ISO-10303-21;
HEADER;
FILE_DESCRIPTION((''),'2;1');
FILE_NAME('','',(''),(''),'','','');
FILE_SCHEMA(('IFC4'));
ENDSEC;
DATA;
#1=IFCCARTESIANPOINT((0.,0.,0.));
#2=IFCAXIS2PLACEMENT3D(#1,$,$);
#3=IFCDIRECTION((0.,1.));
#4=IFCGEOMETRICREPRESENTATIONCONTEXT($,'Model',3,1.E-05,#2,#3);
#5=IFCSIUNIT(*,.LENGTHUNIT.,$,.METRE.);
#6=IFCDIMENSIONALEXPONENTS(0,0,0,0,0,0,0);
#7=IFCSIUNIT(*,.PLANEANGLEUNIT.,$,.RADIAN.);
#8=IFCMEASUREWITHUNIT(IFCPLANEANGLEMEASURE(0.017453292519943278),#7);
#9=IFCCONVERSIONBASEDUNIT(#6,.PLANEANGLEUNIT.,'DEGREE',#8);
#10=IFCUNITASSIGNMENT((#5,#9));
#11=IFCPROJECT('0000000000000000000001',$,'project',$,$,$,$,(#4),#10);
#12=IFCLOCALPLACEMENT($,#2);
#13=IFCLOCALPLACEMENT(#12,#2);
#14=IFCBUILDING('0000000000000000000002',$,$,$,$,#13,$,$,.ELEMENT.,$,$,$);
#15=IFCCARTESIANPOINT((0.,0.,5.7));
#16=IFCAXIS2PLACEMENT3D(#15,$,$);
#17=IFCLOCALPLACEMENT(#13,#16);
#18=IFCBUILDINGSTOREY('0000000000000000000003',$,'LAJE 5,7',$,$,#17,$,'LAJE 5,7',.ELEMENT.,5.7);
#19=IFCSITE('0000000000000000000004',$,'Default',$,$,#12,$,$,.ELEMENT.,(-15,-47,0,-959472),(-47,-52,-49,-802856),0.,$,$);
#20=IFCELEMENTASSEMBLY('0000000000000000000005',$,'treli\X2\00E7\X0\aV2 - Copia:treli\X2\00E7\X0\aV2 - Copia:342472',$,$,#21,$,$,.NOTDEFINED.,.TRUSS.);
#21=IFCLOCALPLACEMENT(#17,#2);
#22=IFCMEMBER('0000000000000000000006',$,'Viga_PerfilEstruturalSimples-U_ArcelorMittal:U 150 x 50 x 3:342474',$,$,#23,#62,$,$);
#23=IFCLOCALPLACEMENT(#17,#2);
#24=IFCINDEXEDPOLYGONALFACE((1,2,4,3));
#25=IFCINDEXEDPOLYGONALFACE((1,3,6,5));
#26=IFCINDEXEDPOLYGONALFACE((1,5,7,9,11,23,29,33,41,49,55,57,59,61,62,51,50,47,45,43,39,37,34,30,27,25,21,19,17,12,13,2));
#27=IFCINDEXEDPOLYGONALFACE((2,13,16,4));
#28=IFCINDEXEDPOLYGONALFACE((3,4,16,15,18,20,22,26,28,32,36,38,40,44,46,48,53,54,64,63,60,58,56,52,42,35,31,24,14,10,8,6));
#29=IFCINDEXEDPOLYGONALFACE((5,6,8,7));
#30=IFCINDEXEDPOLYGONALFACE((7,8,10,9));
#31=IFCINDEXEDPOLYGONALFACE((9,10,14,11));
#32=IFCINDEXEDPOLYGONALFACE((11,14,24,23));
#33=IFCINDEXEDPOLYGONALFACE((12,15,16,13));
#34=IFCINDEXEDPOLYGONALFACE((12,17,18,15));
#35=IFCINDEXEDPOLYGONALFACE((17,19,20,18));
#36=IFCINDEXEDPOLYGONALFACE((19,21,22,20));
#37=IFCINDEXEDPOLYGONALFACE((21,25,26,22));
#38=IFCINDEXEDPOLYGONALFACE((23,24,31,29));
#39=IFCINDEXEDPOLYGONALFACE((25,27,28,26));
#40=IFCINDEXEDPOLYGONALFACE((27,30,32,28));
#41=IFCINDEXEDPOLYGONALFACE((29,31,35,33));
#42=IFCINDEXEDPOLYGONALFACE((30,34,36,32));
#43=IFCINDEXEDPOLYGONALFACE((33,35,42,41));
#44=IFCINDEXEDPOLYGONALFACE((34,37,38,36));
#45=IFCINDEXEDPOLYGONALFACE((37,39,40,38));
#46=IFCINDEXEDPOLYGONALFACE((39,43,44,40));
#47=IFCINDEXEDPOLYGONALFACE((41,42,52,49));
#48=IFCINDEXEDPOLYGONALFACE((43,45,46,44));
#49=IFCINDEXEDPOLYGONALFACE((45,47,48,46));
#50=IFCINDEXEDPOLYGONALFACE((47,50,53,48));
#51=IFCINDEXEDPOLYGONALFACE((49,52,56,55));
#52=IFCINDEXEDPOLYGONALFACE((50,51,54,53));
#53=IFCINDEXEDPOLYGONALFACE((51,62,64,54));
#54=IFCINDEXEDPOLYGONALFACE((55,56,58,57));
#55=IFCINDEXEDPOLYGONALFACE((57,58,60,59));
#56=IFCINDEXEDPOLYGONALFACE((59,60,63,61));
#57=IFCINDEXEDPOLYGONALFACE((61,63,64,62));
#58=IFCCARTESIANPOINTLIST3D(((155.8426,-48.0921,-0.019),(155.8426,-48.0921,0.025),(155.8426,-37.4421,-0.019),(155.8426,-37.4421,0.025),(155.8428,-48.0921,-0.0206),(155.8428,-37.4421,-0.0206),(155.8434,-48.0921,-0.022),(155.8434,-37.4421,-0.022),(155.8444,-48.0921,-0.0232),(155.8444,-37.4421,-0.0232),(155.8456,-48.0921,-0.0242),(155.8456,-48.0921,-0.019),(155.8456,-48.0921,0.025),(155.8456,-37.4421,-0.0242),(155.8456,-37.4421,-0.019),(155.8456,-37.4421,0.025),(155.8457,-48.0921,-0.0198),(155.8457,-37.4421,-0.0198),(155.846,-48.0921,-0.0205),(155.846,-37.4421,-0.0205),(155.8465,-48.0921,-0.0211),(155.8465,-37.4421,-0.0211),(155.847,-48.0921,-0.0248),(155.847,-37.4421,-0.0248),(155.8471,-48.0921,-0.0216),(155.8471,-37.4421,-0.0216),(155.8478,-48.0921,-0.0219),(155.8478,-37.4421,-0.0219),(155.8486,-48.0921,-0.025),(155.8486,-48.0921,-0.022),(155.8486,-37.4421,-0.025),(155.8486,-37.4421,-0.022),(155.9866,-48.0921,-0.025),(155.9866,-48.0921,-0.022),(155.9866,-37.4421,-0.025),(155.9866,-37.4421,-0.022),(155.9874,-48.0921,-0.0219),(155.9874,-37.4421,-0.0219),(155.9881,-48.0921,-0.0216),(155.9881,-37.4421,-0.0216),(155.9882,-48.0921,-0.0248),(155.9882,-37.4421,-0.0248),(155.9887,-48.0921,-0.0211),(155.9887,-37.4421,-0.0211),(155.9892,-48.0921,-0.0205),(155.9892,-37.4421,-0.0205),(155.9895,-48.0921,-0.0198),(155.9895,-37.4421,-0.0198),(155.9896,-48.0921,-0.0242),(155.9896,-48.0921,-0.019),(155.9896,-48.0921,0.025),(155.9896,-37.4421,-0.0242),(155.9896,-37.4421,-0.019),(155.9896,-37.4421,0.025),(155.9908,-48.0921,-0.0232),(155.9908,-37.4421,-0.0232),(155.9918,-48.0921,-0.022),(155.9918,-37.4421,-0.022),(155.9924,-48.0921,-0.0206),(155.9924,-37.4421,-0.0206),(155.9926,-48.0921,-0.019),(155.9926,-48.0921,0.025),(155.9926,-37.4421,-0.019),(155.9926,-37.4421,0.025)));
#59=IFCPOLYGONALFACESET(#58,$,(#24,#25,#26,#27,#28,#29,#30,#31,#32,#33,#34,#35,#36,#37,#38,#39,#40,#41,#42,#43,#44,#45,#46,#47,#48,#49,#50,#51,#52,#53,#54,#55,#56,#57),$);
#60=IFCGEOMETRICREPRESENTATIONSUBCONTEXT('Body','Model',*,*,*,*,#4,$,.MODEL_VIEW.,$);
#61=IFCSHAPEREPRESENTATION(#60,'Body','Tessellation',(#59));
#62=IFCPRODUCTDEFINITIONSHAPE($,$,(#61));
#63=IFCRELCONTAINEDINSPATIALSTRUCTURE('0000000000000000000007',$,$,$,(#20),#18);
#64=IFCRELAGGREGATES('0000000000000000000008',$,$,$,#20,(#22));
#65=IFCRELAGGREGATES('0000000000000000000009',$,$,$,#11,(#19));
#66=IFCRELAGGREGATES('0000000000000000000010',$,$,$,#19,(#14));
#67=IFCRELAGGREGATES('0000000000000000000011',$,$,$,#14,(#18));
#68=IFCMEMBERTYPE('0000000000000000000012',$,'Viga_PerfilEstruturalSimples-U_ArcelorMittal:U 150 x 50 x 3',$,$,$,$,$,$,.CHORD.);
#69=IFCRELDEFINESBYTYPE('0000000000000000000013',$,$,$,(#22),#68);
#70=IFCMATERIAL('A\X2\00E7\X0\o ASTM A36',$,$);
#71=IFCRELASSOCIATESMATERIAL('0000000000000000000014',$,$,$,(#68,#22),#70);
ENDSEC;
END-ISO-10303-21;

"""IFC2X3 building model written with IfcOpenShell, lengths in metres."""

from ifc_helpers import new_model, entity, si_unit, converted_unit, direction, frame, frame_2d, origin, place, context, subcontext, project, spatial, polyline, circle_curve, parameter, trimmed, segment, composite_curve, outline, extrude, source, transform, mapped, material, type_object, type_shapes, element, aggregate, save


model = new_model("IFC2X3")

# Units and contexts
model_context = context("Model", 3, precision=1e-05, world=origin(), true_north=direction((0.0, 1.0)))
body_context = subcontext(model_context, "Body", "Model", "MODEL_VIEW")
ifc_project = project(units=[si_unit("LENGTHUNIT", "METRE"), converted_unit("PLANEANGLEUNIT", "DEGREE", entity("IfcPlaneAngleMeasure", 0.017453292519943278), si_unit("PLANEANGLEUNIT", "RADIAN"), dimensions=[0, 0, 0, 0, 0, 0, 0])], contexts=[model_context])

# Site, building, storey
site_placement = place(None, origin())
site = spatial("IfcSite", under=ifc_project, at=site_placement, Name="Default", CompositionType="ELEMENT", RefLatitude=(-15, -47, 0, -959472), RefLongitude=(-47, -52, -49, -802856), RefElevation=0.0)
building_placement = place(site_placement, origin())
building = spatial("IfcBuilding", under=site, at=building_placement, CompositionType="ELEMENT")
storey_placement = place(building_placement, frame((0.0, 0.0, 5.7)))
storey = spatial("IfcBuildingStorey", under=building, at=storey_placement, Name="LAJE 5,7", LongName="LAJE 5,7", CompositionType="ELEMENT", Elevation=5.7)

# Element assembly, member
assembly_1_placement = place(storey_placement, origin())
assembly_1 = element("IfcElementAssembly", 1, at=assembly_1_placement, inside=storey, Name="treliçaV2 - Copia:treliçaV2 - Copia:342472", AssemblyPlace="NOTDEFINED", PredefinedType="TRUSS")
ifc_material = material(Name="Aço ASTM A36")
member_type_1 = type_object("IfcMemberType", Name="Viga_PerfilEstruturalSimples-U_ArcelorMittal:U 150 x 50 x 3", PredefinedType="CHORD", material=ifc_material)
shared_shape_1 = source(origin(), body_context, "Body", "SweptSolid", [
    extrude(outline(composite_curve([segment(polyline([(-0.069, -0.0192), (0.069, -0.0192)]), True, "CONTINUOUS"), segment(trimmed(circle_curve(frame_2d((0.069, -0.0132), x_axis=(0.0, 1.0)), 0.006), [parameter(180.0)], [parameter(270.0)], True, "PARAMETER"), True, "CONTINUOUS"), segment(polyline([(0.075, -0.0132), (0.075, 0.0308)]), True, "CONTINUOUS"), segment(polyline([(0.075, 0.0308), (0.072, 0.0308)]), True, "CONTINUOUS"), segment(polyline([(0.072, 0.0308), (0.072, -0.0132)]), True, "CONTINUOUS"), segment(trimmed(circle_curve(frame_2d((0.069, -0.0132), x_axis=(0.0, 1.0)), 0.003), [parameter(180.0)], [parameter(270.0)], True, "PARAMETER"), False, "CONTINUOUS"), segment(polyline([(0.069, -0.0162), (-0.069, -0.0162)]), True, "CONTINUOUS"), segment(trimmed(circle_curve(frame_2d((-0.069, -0.0132), x_axis=(0.0, 1.0)), 0.003), [parameter(90.0)], [parameter(180.0)], True, "PARAMETER"), False, "CONTINUOUS"), segment(polyline([(-0.072, -0.0132), (-0.072, 0.0308)]), True, "CONTINUOUS"), segment(polyline([(-0.072, 0.0308), (-0.075, 0.0308)]), True, "CONTINUOUS"), segment(polyline([(-0.075, 0.0308), (-0.075, -0.0132)]), True, "CONTINUOUS"), segment(trimmed(circle_curve(frame_2d((-0.069, -0.0132), x_axis=(0.0, 1.0)), 0.006), [parameter(90.0)], [parameter(180.0)], True, "PARAMETER"), True, "CONTINUOUS")], self_intersect=False)), frame((-5.325, -0.0058, 0.0), z_axis=(1.0, 0.0, 0.0), x_axis=(0.0, 0.0, -1.0)), (0.0, 0.0, 1.0), 10.65),
])
type_shapes(member_type_1, [shared_shape_1])
member_1_placement = place(assembly_1_placement, frame((155.9176, -42.7671, 0.0), z_axis=(1.0, 0.0, 0.0), x_axis=(0.0, 1.0, 0.0)))
member_1 = element("IfcMember", 2, at=member_1_placement, type_object=member_type_1, material=ifc_material, Name="Viga_PerfilEstruturalSimples-U_ArcelorMittal:U 150 x 50 x 3:342474", context=body_context, shape_type="MappedRepresentation", body=[
    mapped(shared_shape_1, transform((0.0, 0.0, 0.0), scale=1.0)),
])
aggregate(assembly_1, [member_1])

save(model, "model.ifc")
